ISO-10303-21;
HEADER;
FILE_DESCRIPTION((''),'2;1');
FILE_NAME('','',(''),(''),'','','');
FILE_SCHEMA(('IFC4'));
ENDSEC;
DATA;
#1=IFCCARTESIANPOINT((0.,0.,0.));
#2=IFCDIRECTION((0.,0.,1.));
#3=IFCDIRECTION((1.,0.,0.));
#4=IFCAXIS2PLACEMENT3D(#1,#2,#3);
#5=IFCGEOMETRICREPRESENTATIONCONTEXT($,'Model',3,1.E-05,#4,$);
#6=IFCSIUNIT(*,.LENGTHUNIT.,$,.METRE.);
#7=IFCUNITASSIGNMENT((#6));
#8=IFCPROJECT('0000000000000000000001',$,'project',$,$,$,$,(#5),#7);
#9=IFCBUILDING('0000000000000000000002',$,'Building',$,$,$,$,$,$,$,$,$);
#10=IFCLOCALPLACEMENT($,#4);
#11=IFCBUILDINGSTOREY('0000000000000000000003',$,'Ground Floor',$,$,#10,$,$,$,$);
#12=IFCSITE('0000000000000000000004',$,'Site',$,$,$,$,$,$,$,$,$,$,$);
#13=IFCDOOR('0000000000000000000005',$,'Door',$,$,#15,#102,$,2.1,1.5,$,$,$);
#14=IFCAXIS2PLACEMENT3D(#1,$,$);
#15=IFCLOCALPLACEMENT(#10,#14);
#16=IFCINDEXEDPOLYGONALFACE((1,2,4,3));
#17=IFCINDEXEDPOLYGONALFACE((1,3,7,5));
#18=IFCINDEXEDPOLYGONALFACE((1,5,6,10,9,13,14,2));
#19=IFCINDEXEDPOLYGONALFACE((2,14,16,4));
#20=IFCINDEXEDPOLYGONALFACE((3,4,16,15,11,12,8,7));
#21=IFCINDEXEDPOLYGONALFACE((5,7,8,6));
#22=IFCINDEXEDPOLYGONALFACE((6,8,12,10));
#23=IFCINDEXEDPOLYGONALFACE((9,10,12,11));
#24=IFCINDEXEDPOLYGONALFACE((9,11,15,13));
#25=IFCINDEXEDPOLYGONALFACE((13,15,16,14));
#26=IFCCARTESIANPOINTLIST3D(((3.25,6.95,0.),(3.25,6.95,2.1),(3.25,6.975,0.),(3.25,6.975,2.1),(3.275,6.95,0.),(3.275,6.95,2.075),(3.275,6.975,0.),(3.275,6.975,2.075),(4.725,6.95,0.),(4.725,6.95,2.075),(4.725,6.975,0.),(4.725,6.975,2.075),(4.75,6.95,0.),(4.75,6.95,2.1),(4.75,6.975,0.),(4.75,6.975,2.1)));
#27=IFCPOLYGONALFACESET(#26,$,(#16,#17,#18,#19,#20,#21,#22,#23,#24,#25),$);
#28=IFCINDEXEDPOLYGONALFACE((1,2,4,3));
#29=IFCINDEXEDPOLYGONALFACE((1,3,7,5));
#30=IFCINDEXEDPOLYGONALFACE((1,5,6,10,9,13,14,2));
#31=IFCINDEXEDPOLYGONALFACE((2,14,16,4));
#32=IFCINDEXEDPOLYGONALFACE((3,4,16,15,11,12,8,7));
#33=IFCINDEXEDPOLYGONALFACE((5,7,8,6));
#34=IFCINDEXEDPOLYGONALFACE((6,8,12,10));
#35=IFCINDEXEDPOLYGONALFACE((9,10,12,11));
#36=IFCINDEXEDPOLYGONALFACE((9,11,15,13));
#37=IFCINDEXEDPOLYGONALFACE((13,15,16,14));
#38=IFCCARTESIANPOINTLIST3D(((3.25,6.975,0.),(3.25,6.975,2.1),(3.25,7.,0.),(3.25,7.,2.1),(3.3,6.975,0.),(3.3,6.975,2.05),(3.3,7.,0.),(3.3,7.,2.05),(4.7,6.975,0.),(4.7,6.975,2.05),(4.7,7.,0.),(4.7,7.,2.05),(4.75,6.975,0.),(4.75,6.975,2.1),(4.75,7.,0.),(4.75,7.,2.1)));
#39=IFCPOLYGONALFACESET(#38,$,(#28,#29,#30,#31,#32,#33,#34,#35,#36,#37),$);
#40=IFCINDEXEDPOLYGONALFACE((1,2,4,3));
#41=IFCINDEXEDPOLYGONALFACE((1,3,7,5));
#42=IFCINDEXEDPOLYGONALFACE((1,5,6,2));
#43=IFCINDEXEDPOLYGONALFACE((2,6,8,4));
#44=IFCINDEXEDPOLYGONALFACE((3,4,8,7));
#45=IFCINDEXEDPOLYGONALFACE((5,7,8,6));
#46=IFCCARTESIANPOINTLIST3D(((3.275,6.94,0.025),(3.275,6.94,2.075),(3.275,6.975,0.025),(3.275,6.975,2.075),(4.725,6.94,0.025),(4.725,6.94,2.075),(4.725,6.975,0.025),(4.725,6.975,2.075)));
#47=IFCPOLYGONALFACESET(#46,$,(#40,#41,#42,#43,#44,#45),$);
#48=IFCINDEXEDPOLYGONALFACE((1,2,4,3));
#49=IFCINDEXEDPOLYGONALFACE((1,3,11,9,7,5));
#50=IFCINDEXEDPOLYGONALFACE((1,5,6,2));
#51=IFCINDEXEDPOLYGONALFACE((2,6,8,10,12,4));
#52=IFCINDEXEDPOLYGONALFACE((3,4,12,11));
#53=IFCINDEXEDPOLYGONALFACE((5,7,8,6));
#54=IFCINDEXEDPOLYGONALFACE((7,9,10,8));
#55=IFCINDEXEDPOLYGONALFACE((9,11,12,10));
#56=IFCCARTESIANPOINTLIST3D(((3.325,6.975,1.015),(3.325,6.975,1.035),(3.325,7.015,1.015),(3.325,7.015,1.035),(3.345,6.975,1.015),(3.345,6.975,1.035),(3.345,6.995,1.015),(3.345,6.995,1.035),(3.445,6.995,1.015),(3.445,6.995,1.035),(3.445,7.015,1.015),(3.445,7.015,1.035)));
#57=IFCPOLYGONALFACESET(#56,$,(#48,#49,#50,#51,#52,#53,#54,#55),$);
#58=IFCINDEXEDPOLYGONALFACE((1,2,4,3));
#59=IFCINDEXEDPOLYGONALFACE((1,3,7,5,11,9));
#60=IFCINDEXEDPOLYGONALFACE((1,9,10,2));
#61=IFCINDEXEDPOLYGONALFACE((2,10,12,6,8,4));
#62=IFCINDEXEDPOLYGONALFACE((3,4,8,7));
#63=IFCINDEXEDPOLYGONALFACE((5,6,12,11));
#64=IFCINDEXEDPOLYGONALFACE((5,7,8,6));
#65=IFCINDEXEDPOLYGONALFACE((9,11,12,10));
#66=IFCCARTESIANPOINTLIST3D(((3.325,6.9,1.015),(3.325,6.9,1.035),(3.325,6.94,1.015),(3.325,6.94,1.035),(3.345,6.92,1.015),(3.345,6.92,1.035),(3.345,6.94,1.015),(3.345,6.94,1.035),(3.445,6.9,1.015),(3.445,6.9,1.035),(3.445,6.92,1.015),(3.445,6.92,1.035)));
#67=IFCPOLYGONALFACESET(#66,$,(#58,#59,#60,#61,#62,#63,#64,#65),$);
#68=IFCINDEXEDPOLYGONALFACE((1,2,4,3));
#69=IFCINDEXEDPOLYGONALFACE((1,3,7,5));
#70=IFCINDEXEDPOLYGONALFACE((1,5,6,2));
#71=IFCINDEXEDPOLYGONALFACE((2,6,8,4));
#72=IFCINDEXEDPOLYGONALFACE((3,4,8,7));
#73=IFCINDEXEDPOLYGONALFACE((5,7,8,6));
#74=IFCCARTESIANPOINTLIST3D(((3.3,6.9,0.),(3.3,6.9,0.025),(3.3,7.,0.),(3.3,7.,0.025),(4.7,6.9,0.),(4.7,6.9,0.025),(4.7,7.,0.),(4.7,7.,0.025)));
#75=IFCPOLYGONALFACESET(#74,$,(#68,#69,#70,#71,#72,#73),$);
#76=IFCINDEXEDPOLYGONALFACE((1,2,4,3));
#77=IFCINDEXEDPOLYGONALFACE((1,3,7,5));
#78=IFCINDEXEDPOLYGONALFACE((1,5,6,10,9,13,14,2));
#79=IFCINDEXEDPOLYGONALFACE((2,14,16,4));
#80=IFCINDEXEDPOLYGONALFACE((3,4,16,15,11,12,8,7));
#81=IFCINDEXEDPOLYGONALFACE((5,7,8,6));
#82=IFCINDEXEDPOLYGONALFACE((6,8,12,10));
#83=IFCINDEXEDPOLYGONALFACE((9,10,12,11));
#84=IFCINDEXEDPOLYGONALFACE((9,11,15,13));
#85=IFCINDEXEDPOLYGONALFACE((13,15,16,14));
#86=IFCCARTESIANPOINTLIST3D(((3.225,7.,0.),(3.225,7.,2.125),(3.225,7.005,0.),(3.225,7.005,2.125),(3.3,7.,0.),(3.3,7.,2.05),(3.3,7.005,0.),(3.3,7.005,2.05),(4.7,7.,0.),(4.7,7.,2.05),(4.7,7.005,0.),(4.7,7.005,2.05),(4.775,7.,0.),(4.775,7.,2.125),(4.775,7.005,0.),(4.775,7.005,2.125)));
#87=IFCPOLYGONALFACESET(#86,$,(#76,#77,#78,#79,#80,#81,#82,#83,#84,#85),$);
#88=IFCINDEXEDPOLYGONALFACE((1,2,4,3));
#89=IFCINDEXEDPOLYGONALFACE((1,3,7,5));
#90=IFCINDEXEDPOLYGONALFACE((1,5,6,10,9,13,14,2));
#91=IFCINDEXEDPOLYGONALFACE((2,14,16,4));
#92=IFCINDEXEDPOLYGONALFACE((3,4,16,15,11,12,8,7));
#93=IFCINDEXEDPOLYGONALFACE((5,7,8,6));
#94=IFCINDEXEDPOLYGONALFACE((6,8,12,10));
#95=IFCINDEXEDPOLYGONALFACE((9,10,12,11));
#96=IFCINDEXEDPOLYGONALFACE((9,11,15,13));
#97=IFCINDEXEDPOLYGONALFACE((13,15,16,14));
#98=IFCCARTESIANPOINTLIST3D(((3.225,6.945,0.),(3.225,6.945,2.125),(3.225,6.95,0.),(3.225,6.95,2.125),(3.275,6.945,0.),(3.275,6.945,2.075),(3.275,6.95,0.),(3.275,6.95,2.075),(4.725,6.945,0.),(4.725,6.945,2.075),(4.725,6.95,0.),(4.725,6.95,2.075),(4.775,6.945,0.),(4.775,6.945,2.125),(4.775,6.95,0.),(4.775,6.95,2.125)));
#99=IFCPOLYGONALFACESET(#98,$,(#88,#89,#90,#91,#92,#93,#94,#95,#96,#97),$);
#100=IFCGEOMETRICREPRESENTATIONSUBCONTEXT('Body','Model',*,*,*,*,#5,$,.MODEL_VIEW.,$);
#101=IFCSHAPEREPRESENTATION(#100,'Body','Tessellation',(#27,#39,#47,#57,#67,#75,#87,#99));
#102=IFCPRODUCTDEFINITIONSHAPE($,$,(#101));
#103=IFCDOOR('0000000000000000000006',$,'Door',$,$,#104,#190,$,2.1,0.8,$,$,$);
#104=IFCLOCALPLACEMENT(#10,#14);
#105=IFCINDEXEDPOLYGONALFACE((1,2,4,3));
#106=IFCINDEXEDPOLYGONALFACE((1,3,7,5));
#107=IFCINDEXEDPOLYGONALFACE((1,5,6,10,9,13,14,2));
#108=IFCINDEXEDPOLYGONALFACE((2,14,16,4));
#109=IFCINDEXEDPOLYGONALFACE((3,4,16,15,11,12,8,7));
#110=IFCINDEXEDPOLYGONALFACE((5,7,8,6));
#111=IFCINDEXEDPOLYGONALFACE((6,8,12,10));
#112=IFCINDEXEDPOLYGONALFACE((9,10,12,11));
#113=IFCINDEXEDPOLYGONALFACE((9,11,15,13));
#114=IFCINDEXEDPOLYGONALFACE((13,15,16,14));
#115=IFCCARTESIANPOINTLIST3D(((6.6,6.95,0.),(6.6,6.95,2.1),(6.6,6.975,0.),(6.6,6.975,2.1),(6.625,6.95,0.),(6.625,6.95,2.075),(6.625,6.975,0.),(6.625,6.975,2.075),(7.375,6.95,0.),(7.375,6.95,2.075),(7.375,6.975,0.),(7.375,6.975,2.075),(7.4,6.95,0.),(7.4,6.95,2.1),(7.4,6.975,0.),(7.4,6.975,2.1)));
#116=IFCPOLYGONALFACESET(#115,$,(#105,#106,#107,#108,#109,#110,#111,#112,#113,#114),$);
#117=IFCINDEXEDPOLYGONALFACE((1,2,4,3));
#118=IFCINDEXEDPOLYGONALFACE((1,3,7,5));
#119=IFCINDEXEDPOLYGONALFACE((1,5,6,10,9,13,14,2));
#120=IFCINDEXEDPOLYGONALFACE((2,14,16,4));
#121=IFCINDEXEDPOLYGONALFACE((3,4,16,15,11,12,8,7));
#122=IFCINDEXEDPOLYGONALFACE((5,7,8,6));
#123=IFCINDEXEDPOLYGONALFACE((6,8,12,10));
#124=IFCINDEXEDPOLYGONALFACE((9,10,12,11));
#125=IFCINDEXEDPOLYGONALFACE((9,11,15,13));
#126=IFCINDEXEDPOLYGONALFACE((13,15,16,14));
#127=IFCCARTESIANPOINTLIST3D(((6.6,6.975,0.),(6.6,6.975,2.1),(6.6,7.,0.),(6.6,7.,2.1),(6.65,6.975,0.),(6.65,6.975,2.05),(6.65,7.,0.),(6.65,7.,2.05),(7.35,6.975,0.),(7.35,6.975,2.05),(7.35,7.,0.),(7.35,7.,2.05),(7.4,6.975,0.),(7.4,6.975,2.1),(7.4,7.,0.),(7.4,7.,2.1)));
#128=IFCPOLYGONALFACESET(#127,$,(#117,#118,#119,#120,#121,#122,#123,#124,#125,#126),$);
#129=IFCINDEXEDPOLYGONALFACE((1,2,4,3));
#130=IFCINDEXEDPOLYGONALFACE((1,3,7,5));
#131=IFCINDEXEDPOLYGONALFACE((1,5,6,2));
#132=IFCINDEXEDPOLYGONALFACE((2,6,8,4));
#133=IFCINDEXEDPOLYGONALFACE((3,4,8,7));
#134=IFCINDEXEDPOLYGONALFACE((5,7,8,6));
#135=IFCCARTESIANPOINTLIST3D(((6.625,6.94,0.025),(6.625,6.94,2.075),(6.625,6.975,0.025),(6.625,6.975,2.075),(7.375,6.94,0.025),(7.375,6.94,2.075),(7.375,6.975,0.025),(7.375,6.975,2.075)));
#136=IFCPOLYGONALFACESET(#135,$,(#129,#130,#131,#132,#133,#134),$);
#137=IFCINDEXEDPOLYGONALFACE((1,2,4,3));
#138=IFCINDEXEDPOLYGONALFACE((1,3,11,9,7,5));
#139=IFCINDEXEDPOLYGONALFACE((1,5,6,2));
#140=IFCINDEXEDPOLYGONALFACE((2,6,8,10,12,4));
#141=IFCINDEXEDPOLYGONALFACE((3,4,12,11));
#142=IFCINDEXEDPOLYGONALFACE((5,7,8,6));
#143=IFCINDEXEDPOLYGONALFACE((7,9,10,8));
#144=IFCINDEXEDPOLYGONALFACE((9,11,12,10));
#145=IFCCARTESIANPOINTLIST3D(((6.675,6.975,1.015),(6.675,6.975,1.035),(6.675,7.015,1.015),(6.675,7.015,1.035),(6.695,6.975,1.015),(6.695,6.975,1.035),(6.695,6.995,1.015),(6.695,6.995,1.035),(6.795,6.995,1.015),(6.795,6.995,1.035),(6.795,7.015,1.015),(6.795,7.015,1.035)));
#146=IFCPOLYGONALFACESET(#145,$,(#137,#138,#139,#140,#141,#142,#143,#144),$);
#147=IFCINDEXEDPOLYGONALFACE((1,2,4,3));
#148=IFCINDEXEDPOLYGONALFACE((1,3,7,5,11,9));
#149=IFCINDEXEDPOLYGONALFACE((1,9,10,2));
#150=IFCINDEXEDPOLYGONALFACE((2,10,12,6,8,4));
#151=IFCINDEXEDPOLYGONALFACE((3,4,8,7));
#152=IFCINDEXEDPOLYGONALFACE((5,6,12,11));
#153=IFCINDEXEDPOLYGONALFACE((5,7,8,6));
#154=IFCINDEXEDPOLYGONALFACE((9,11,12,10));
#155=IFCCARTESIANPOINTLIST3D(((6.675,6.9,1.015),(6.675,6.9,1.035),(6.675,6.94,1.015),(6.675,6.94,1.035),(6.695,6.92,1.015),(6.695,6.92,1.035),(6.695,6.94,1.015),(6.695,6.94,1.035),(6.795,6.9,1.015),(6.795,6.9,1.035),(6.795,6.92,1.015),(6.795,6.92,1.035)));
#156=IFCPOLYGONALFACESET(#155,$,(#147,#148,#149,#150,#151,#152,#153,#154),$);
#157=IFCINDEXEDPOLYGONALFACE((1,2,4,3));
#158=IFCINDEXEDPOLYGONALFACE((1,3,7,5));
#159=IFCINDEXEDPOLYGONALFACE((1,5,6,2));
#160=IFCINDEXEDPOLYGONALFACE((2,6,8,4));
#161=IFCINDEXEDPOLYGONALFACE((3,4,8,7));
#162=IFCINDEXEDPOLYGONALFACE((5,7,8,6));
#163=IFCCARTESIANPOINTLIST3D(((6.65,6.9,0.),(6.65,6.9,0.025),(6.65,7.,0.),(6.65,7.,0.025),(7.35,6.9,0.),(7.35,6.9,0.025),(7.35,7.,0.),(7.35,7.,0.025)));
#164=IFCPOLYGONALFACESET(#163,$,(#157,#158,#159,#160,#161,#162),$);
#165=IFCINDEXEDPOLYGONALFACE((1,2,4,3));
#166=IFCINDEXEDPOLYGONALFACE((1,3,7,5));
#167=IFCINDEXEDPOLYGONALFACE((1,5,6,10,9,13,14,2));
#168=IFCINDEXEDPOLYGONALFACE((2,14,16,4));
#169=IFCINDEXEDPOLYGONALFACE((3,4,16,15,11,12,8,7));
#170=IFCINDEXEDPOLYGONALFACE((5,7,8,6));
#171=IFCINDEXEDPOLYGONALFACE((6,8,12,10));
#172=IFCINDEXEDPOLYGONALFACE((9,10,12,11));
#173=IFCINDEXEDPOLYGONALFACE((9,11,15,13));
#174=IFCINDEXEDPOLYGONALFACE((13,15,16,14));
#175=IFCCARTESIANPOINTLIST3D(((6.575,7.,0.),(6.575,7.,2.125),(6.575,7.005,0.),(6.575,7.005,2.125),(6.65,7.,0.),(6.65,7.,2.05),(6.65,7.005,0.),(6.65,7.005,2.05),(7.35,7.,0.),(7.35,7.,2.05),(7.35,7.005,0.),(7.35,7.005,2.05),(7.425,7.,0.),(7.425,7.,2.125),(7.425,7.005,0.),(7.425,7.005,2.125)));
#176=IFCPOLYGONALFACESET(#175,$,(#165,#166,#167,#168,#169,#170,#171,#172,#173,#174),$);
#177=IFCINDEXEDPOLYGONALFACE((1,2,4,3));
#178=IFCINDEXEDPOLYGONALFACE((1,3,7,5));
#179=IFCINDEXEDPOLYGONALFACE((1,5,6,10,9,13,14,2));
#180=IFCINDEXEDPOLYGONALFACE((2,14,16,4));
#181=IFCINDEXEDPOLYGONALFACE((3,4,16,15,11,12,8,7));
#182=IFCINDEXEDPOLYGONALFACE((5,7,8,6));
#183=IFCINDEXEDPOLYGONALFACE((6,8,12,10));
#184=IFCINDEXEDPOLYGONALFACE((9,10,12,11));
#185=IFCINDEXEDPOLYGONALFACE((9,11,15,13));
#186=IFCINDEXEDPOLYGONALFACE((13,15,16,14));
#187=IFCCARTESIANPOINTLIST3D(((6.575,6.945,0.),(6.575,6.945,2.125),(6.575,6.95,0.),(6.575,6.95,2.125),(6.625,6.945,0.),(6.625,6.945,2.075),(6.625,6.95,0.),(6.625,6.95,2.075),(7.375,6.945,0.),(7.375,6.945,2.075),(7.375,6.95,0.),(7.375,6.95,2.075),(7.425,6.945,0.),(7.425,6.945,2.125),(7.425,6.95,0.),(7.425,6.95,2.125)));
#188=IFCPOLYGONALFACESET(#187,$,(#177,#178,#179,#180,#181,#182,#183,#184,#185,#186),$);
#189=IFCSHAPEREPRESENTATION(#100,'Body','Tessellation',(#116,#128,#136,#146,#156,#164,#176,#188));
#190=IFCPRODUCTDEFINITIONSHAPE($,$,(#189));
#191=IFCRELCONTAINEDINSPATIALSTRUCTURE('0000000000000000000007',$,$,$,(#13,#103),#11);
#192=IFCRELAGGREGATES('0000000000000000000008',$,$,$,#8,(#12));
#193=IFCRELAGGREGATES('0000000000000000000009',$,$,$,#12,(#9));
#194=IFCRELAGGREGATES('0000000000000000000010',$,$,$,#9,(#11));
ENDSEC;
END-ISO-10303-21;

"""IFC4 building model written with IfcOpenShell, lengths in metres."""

from ifc_helpers import new_model, si_unit, frame, origin_with_axes, place, context, subcontext, project, spatial, line, indexed_curve, outline, extrude, element, save


model = new_model("IFC4")

# Units and contexts
model_context = context("Model", 3, precision=1e-05, world=origin_with_axes())
body_context = subcontext(model_context, "Body", "Model", "MODEL_VIEW")
ifc_project = project(units=[si_unit("LENGTHUNIT", "METRE")], contexts=[model_context])

# Site, building, storey
site = spatial("IfcSite", under=ifc_project, Name="Site")
building = spatial("IfcBuilding", under=site, Name="Building")
storey_placement = place(None, origin_with_axes())
storey = spatial("IfcBuildingStorey", under=building, at=storey_placement, Name="Ground Floor")

# Doors
door_1_placement = place(storey_placement, frame((4.75, 7.0, 0.0), z_axis=(0.0, 0.0, 1.0), x_axis=(-1.0, 0.0, 0.0)))
element("IfcDoor", 1, at=door_1_placement, inside=storey, Name="Door", OverallHeight=2.1, OverallWidth=1.5, context=body_context, shape_type="SweptSolid", body=[
    extrude(outline(indexed_curve([(0.0, 0.0), (0.0, 2.1), (1.5, 2.1), (1.5, 0.0), (1.475, 0.0), (1.475, 2.075), (0.025, 2.075), (0.025, 0.0)], segments=[line(1, 2, 3, 4, 5, 6, 7, 8, 1)])), frame((0.0, 0.025, 0.0), z_axis=(0.0, -1.0, 0.0), x_axis=(1.0, 0.0, 0.0)), (0.0, 0.0, -1.0), 0.025),
    extrude(outline(indexed_curve([(0.0, 0.0), (0.0, 2.1), (1.5, 2.1), (1.5, 0.0), (1.45, 0.0), (1.45, 2.05), (0.05, 2.05), (0.05, 0.0)], segments=[line(1, 2, 3, 4, 5, 6, 7, 8, 1)])), frame((0.0, 0.0, 0.0), z_axis=(0.0, -1.0, 0.0), x_axis=(1.0, 0.0, 0.0)), (0.0, 0.0, -1.0), 0.025),
    extrude(outline(indexed_curve([(0.0, 0.0), (1.45, 0.0), (1.45, 0.035), (0.0, 0.035)], segments=[line(1, 2, 3, 4, 1)])), frame((0.025, 0.025, 0.025), z_axis=(0.0, 0.0, 1.0), x_axis=(1.0, 0.0, 0.0)), (0.0, 0.0, 1.0), 2.05),
    extrude(outline(indexed_curve([(0.0, 0.0), (0.0, -0.04), (-0.12, -0.04), (-0.12, -0.02), (-0.02, -0.02), (-0.02, 0.0)], segments=[line(1, 2, 3, 4, 5, 6, 1)])), frame((1.425, 0.025, 1.015), z_axis=(0.0, 0.0, 1.0), x_axis=(1.0, 0.0, 0.0)), (0.0, 0.0, 1.0), 0.02),
    extrude(outline(indexed_curve([(0.0, 0.0), (0.0, 0.04), (-0.12, 0.04), (-0.12, 0.02), (-0.02, 0.02), (-0.02, 0.0)], segments=[line(1, 2, 3, 4, 5, 6, 1)])), frame((1.425, 0.06, 1.015), z_axis=(0.0, 0.0, 1.0), x_axis=(1.0, 0.0, 0.0)), (0.0, 0.0, 1.0), 0.02),
    extrude(outline(indexed_curve([(0.0, 0.0), (1.4, 0.0), (1.4, 0.1), (0.0, 0.1)], segments=[line(1, 2, 3, 4, 1)])), frame((0.05, 0.0, 0.0), z_axis=(0.0, 0.0, 1.0), x_axis=(1.0, 0.0, 0.0)), (0.0, 0.0, 1.0), 0.025),
    extrude(outline(indexed_curve([(0.0, 0.0), (0.0, 2.125), (1.55, 2.125), (1.55, 0.0), (1.475, 0.0), (1.475, 2.05), (0.075, 2.05), (0.075, 0.0)], segments=[line(1, 2, 3, 4, 5, 6, 7, 8, 1)])), frame((-0.025, -0.005, 0.0), z_axis=(0.0, -1.0, 0.0), x_axis=(1.0, 0.0, 0.0)), (0.0, 0.0, -1.0), 0.005),
    extrude(outline(indexed_curve([(0.0, 0.0), (0.0, 2.125), (1.55, 2.125), (1.55, 0.0), (1.5, 0.0), (1.5, 2.075), (0.05, 2.075), (0.05, 0.0)], segments=[line(1, 2, 3, 4, 5, 6, 7, 8, 1)])), frame((-0.025, 0.05, 0.0), z_axis=(0.0, -1.0, 0.0), x_axis=(1.0, 0.0, 0.0)), (0.0, 0.0, -1.0), 0.005),
])
door_2_placement = place(storey_placement, frame((7.4, 7.0, 0.0), z_axis=(0.0, 0.0, 1.0), x_axis=(-1.0, 0.0, 0.0)))
element("IfcDoor", 2, at=door_2_placement, inside=storey, Name="Door", OverallHeight=2.1, OverallWidth=0.8, context=body_context, shape_type="SweptSolid", body=[
    extrude(outline(indexed_curve([(0.0, 0.0), (0.0, 2.1), (0.8, 2.1), (0.8, 0.0), (0.775, 0.0), (0.775, 2.075), (0.025, 2.075), (0.025, 0.0)], segments=[line(1, 2, 3, 4, 5, 6, 7, 8, 1)])), frame((0.0, 0.025, 0.0), z_axis=(0.0, -1.0, 0.0), x_axis=(1.0, 0.0, 0.0)), (0.0, 0.0, -1.0), 0.025),
    extrude(outline(indexed_curve([(0.0, 0.0), (0.0, 2.1), (0.8, 2.1), (0.8, 0.0), (0.75, 0.0), (0.75, 2.05), (0.05, 2.05), (0.05, 0.0)], segments=[line(1, 2, 3, 4, 5, 6, 7, 8, 1)])), frame((0.0, 0.0, 0.0), z_axis=(0.0, -1.0, 0.0), x_axis=(1.0, 0.0, 0.0)), (0.0, 0.0, -1.0), 0.025),
    extrude(outline(indexed_curve([(0.0, 0.0), (0.75, 0.0), (0.75, 0.035), (0.0, 0.035)], segments=[line(1, 2, 3, 4, 1)])), frame((0.025, 0.025, 0.025), z_axis=(0.0, 0.0, 1.0), x_axis=(1.0, 0.0, 0.0)), (0.0, 0.0, 1.0), 2.05),
    extrude(outline(indexed_curve([(0.0, 0.0), (0.0, -0.04), (-0.12, -0.04), (-0.12, -0.02), (-0.02, -0.02), (-0.02, 0.0)], segments=[line(1, 2, 3, 4, 5, 6, 1)])), frame((0.725, 0.025, 1.015), z_axis=(0.0, 0.0, 1.0), x_axis=(1.0, 0.0, 0.0)), (0.0, 0.0, 1.0), 0.02),
    extrude(outline(indexed_curve([(0.0, 0.0), (0.0, 0.04), (-0.12, 0.04), (-0.12, 0.02), (-0.02, 0.02), (-0.02, 0.0)], segments=[line(1, 2, 3, 4, 5, 6, 1)])), frame((0.725, 0.06, 1.015), z_axis=(0.0, 0.0, 1.0), x_axis=(1.0, 0.0, 0.0)), (0.0, 0.0, 1.0), 0.02),
    extrude(outline(indexed_curve([(0.0, 0.0), (0.7, 0.0), (0.7, 0.1), (0.0, 0.1)], segments=[line(1, 2, 3, 4, 1)])), frame((0.05, 0.0, 0.0), z_axis=(0.0, 0.0, 1.0), x_axis=(1.0, 0.0, 0.0)), (0.0, 0.0, 1.0), 0.025),
    extrude(outline(indexed_curve([(0.0, 0.0), (0.0, 2.125), (0.85, 2.125), (0.85, 0.0), (0.775, 0.0), (0.775, 2.05), (0.075, 2.05), (0.075, 0.0)], segments=[line(1, 2, 3, 4, 5, 6, 7, 8, 1)])), frame((-0.025, -0.005, 0.0), z_axis=(0.0, -1.0, 0.0), x_axis=(1.0, 0.0, 0.0)), (0.0, 0.0, -1.0), 0.005),
    extrude(outline(indexed_curve([(0.0, 0.0), (0.0, 2.125), (0.85, 2.125), (0.85, 0.0), (0.8, 0.0), (0.8, 2.075), (0.05, 2.075), (0.05, 0.0)], segments=[line(1, 2, 3, 4, 5, 6, 7, 8, 1)])), frame((-0.025, 0.05, 0.0), z_axis=(0.0, -1.0, 0.0), x_axis=(1.0, 0.0, 0.0)), (0.0, 0.0, -1.0), 0.005),
])

save(model, "model.ifc")
